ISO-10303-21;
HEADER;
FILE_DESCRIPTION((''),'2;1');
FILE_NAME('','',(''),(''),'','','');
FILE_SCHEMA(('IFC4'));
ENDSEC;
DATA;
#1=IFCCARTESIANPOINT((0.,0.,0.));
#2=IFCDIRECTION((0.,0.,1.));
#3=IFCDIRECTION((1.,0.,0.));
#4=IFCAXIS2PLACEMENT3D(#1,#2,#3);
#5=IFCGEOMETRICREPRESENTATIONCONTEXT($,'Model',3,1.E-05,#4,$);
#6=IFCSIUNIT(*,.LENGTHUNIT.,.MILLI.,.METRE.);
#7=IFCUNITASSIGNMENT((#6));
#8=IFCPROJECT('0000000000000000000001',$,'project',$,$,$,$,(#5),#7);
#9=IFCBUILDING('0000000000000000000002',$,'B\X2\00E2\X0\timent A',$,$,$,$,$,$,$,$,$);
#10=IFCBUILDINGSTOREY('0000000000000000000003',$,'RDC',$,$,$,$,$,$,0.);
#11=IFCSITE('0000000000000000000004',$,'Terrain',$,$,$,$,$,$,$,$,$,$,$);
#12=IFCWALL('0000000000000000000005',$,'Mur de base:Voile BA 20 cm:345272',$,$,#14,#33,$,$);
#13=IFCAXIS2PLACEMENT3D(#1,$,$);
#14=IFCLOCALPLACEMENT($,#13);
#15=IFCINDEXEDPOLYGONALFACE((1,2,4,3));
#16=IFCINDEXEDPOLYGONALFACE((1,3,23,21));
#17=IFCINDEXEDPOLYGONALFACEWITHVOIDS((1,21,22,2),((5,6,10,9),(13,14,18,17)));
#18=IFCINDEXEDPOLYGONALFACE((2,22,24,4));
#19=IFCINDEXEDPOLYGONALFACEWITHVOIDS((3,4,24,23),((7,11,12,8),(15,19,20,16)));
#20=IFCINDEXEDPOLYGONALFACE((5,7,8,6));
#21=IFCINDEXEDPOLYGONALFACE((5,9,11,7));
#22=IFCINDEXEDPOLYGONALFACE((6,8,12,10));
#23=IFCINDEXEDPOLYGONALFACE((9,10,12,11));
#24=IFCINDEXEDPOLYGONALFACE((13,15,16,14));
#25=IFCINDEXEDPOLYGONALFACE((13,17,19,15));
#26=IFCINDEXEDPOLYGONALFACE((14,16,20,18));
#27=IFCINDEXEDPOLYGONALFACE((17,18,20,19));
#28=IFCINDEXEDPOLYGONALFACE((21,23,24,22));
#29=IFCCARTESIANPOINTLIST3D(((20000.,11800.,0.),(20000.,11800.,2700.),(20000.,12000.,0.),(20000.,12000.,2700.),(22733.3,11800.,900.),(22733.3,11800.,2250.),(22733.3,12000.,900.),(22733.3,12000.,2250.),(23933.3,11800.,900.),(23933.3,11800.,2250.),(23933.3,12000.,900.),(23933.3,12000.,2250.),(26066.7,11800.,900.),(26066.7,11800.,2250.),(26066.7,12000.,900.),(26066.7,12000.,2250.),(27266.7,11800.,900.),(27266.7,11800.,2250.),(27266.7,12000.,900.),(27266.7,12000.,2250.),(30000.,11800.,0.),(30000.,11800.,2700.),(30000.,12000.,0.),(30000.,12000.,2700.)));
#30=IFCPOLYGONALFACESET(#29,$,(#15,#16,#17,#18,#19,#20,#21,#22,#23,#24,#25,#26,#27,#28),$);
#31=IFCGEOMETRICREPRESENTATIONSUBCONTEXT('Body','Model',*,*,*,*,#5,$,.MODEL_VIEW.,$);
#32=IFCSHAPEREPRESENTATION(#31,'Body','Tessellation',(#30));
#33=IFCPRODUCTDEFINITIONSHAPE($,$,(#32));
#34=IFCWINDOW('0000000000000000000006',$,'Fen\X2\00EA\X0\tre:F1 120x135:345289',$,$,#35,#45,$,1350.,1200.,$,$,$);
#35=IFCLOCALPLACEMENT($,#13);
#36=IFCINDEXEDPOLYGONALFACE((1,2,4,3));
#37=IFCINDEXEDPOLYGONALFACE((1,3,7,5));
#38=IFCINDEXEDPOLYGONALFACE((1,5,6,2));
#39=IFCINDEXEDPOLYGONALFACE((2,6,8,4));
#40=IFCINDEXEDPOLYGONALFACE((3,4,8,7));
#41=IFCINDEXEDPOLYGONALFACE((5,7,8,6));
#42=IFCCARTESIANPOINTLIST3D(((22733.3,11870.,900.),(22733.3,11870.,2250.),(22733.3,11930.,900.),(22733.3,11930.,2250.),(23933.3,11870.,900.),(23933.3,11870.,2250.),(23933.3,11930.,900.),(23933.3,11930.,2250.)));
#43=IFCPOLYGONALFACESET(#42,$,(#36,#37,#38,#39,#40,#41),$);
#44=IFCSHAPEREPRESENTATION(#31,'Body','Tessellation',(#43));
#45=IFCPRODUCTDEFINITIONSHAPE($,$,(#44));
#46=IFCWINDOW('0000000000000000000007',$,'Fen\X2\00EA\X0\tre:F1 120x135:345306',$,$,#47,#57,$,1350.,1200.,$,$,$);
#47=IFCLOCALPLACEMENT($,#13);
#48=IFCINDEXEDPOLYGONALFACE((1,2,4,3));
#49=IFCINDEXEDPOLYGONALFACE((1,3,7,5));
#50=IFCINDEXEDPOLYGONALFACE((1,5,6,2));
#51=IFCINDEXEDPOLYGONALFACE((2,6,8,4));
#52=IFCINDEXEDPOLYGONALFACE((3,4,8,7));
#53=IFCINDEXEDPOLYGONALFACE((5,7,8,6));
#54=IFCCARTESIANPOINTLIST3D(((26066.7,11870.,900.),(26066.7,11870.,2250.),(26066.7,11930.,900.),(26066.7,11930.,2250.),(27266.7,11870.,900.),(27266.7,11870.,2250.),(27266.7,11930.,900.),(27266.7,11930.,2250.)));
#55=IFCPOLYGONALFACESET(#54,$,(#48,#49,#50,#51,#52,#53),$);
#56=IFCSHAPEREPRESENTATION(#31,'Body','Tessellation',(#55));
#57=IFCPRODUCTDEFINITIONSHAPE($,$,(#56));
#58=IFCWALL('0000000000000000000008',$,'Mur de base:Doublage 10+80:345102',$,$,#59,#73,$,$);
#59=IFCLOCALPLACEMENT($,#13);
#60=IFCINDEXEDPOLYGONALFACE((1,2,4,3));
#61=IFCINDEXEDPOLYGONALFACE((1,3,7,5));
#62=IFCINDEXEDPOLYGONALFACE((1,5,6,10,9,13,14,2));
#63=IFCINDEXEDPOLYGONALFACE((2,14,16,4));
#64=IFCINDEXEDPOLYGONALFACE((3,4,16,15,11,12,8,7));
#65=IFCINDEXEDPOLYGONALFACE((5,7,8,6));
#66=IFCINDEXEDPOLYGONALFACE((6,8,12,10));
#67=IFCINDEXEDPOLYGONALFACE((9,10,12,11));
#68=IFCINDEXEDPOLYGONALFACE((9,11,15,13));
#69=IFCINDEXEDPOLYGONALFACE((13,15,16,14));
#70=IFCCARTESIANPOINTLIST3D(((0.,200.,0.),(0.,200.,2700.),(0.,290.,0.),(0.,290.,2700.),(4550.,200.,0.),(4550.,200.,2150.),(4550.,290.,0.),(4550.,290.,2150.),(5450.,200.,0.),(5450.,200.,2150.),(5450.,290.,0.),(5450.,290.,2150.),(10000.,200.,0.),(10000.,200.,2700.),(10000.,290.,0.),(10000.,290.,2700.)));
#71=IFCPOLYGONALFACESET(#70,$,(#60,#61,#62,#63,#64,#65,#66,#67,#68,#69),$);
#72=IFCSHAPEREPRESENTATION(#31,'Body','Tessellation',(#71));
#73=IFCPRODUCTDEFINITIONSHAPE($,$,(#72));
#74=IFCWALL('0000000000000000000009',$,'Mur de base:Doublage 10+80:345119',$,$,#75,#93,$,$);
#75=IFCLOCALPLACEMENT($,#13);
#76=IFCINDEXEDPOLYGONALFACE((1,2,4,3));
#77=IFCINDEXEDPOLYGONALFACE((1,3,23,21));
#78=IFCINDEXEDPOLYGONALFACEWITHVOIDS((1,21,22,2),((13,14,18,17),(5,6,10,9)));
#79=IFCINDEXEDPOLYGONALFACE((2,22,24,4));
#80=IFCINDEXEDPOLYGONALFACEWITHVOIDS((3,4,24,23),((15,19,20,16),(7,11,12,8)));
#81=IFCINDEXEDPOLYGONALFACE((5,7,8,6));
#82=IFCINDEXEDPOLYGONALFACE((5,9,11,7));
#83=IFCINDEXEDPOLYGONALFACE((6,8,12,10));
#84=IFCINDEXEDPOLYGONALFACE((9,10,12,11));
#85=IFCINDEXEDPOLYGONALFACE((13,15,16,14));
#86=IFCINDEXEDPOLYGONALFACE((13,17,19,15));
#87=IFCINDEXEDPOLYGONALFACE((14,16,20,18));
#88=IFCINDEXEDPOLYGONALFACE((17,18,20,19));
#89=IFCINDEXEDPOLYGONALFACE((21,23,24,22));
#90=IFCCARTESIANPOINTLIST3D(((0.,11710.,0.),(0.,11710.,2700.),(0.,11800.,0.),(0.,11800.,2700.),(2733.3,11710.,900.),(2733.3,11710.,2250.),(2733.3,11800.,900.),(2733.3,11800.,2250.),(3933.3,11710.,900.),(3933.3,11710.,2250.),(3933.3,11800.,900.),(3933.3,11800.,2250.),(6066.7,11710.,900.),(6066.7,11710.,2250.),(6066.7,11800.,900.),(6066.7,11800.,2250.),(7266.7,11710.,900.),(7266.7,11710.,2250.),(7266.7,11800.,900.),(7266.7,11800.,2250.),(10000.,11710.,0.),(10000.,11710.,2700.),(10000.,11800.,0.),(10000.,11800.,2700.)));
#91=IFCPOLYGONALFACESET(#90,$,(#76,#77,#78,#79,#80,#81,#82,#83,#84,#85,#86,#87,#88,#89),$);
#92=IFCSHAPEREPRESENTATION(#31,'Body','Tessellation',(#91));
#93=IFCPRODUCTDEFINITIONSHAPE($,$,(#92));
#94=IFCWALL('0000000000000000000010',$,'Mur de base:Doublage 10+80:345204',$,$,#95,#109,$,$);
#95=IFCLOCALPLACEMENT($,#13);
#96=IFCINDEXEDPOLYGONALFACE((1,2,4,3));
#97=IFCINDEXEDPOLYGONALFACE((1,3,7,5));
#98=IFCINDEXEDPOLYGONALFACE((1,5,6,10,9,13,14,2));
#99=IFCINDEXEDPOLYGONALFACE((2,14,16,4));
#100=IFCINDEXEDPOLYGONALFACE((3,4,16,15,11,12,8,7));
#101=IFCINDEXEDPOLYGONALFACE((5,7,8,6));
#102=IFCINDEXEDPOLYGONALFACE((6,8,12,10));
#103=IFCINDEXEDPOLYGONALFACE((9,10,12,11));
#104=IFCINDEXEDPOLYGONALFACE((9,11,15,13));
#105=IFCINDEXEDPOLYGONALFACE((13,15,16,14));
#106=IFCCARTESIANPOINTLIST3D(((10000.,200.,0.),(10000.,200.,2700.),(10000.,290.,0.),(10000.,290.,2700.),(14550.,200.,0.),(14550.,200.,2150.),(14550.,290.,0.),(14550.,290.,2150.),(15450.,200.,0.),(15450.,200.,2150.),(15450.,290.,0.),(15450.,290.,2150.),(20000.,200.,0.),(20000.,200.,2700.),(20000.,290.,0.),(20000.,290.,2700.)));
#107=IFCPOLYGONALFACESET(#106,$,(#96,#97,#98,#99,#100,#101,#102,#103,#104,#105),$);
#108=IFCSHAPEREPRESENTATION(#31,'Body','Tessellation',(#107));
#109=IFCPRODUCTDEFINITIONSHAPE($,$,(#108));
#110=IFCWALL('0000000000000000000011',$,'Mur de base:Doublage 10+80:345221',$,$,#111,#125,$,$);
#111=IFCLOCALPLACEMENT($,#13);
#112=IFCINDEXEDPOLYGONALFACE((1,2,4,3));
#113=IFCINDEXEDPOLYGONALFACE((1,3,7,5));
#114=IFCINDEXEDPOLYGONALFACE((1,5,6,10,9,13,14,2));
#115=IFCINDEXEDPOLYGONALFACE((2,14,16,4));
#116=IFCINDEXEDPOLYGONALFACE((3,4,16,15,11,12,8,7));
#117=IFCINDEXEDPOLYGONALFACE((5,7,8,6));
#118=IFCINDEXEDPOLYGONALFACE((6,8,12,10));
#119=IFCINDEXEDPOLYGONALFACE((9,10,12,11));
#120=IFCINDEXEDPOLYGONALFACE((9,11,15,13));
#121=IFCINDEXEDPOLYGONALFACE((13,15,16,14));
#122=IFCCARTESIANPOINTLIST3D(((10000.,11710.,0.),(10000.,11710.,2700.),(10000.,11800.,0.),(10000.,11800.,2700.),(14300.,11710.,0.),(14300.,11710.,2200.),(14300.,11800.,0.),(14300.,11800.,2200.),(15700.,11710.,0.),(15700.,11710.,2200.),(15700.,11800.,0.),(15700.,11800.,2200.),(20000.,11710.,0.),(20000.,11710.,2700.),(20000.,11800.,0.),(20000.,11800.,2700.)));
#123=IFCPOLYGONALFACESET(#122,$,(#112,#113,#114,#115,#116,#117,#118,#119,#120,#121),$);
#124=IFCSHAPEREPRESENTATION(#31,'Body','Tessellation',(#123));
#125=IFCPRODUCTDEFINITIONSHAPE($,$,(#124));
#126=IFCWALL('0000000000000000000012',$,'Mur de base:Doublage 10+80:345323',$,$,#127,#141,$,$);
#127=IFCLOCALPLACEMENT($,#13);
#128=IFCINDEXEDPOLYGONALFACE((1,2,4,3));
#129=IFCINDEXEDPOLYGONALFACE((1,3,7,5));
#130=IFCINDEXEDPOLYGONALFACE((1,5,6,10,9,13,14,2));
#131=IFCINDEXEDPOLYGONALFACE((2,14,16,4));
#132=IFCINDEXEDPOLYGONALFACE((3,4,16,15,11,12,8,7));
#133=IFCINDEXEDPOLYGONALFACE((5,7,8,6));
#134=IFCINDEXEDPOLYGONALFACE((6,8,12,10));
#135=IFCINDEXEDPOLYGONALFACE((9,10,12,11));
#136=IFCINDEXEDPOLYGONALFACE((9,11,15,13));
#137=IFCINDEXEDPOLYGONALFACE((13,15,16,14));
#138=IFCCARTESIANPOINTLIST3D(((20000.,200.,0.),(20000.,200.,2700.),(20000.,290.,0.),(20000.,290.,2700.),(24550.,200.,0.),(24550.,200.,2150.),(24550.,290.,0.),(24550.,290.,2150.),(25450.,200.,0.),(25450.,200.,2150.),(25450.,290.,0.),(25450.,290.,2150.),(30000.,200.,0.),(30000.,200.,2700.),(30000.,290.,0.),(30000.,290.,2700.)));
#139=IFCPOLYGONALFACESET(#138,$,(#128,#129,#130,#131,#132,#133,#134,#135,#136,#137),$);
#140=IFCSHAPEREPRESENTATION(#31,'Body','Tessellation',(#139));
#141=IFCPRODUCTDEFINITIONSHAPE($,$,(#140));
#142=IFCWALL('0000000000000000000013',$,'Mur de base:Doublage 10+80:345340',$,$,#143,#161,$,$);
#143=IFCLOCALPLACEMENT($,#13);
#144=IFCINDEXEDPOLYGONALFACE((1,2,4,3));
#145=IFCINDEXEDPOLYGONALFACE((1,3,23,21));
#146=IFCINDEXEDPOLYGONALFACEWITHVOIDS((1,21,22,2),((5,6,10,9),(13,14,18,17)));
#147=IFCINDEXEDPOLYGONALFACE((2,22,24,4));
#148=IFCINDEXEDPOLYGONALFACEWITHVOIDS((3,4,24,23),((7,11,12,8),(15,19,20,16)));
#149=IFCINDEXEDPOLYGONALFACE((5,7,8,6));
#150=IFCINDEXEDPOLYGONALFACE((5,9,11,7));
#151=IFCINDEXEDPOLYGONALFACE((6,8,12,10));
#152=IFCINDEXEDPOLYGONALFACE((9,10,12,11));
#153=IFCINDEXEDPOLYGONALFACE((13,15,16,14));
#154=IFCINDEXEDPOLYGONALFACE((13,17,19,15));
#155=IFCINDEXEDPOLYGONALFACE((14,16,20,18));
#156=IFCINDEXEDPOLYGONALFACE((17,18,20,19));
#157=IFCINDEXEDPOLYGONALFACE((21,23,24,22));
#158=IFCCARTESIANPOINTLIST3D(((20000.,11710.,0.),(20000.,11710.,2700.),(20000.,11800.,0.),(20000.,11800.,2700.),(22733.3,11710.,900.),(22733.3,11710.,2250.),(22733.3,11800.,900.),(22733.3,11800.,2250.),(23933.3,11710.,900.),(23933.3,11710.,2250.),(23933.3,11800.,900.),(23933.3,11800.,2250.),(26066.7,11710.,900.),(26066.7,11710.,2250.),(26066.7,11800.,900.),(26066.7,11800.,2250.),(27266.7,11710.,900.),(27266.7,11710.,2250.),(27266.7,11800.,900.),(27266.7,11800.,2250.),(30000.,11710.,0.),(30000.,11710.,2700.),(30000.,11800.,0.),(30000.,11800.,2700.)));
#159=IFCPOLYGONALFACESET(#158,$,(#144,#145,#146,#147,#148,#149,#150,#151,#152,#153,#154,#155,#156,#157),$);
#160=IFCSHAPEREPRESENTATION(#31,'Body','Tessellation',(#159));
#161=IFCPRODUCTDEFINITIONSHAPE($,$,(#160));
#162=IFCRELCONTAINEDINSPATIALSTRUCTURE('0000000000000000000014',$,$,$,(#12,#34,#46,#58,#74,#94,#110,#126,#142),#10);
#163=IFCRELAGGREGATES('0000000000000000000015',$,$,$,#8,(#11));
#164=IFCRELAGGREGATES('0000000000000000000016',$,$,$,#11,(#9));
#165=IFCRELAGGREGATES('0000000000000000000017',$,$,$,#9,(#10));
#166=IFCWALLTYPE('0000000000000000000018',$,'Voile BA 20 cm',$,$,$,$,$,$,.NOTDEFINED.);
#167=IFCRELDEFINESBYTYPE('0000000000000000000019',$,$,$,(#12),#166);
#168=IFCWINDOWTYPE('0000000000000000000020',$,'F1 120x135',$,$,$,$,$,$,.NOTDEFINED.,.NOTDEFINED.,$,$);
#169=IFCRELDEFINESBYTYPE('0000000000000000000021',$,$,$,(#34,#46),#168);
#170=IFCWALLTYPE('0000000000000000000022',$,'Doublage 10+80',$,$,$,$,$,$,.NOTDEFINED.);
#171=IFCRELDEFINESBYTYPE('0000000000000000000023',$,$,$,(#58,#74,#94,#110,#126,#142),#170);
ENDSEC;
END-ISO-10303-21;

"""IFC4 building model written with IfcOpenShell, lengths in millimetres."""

from ifc_helpers import new_model, si_unit, frame, frame_2d, origin_with_axes, place, context, subcontext, project, spatial, rectangle, extrude, type_object, element, fill, save


model = new_model("IFC4")

# Units and contexts
model_context = context("Model", 3, precision=1e-05, world=origin_with_axes())
body_context = subcontext(model_context, "Body", "Model", "MODEL_VIEW")
ifc_project = project(units=[si_unit("LENGTHUNIT", "METRE", prefix="MILLI")], contexts=[model_context])

# Site, building, storey
site = spatial("IfcSite", under=ifc_project, Name="Terrain")
building = spatial("IfcBuilding", under=site, Name="Bâtiment A")
storey = spatial("IfcBuildingStorey", under=building, Name="RDC", Elevation=0.0)

# Shared definitions
wall_type_1 = type_object("IfcWallType", Name="Voile BA 20 cm", PredefinedType="NOTDEFINED")

# Shared definitions
window_type = type_object("IfcWindowType", Name="F1 120x135", PartitioningType="NOTDEFINED", PredefinedType="NOTDEFINED")

# Wall, openings, windows
wall_1_placement = place(None, origin_with_axes())
wall_1 = element("IfcWall", 1, at=wall_1_placement, inside=storey, type_object=wall_type_1, Name="Mur de base:Voile BA 20 cm:345272", context=body_context, shape_type="SweptSolid", body=[
    extrude(rectangle(XDim=10000.0, YDim=200.0, at=frame_2d((25000.0, 11900.0))), origin_with_axes(), (0.0, 0.0, 1.0), 2700.0),
])
opening_1_placement = place(None, origin_with_axes())
opening_1 = element("IfcOpeningElement", 2, at=opening_1_placement, cuts=wall_1, context=body_context, shape_type="SweptSolid", body=[
    extrude(rectangle(XDim=1200.0, YDim=320.0, at=frame_2d((23333.3, 11900.0))), frame((0.0, 0.0, 900.0), z_axis=(0.0, 0.0, 1.0), x_axis=(1.0, 0.0, 0.0)), (0.0, 0.0, 1.0), 1350.0),
])
opening_2_placement = place(None, origin_with_axes())
opening_2 = element("IfcOpeningElement", 3, at=opening_2_placement, cuts=wall_1, context=body_context, shape_type="SweptSolid", body=[
    extrude(rectangle(XDim=1200.0, YDim=320.0, at=frame_2d((26666.7, 11900.0))), frame((0.0, 0.0, 900.0), z_axis=(0.0, 0.0, 1.0), x_axis=(1.0, 0.0, 0.0)), (0.0, 0.0, 1.0), 1350.0),
])
window_1_placement = place(None, origin_with_axes())
window_1 = element("IfcWindow", 4, at=window_1_placement, inside=storey, type_object=window_type, Name="Fenêtre:F1 120x135:345289", OverallHeight=1350.0, OverallWidth=1200.0, context=body_context, shape_type="SweptSolid", body=[
    extrude(rectangle(XDim=1200.0, YDim=60.0, at=frame_2d((23333.3, 11900.0))), frame((0.0, 0.0, 900.0), z_axis=(0.0, 0.0, 1.0), x_axis=(1.0, 0.0, 0.0)), (0.0, 0.0, 1.0), 1350.0),
])
fill(opening_1, window_1)
window_2_placement = place(None, origin_with_axes())
window_2 = element("IfcWindow", 5, at=window_2_placement, inside=storey, type_object=window_type, Name="Fenêtre:F1 120x135:345306", OverallHeight=1350.0, OverallWidth=1200.0, context=body_context, shape_type="SweptSolid", body=[
    extrude(rectangle(XDim=1200.0, YDim=60.0, at=frame_2d((26666.7, 11900.0))), frame((0.0, 0.0, 900.0), z_axis=(0.0, 0.0, 1.0), x_axis=(1.0, 0.0, 0.0)), (0.0, 0.0, 1.0), 1350.0),
])
fill(opening_2, window_2)

# Wall, opening
wall_type_2 = type_object("IfcWallType", Name="Doublage 10+80", PredefinedType="NOTDEFINED")
wall_2_placement = place(None, origin_with_axes())
wall_2 = element("IfcWall", 6, at=wall_2_placement, inside=storey, type_object=wall_type_2, Name="Mur de base:Doublage 10+80:345102", context=body_context, shape_type="SweptSolid", body=[
    extrude(rectangle(XDim=10000.0, YDim=90.0, at=frame_2d((5000.0, 245.0))), origin_with_axes(), (0.0, 0.0, 1.0), 2700.0),
])
opening_3_placement = place(None, origin_with_axes())
element("IfcOpeningElement", 7, at=opening_3_placement, cuts=wall_2, context=body_context, shape_type="SweptSolid", body=[
    extrude(rectangle(XDim=900.0, YDim=210.0, at=frame_2d((5000.0, 245.0))), origin_with_axes(), (0.0, 0.0, 1.0), 2150.0),
])

# Wall, openings
wall_3_placement = place(None, origin_with_axes())
wall_3 = element("IfcWall", 8, at=wall_3_placement, inside=storey, type_object=wall_type_2, Name="Mur de base:Doublage 10+80:345119", context=body_context, shape_type="SweptSolid", body=[
    extrude(rectangle(XDim=10000.0, YDim=90.0, at=frame_2d((5000.0, 11755.0))), origin_with_axes(), (0.0, 0.0, 1.0), 2700.0),
])
opening_4_placement = place(None, origin_with_axes())
element("IfcOpeningElement", 9, at=opening_4_placement, cuts=wall_3, context=body_context, shape_type="SweptSolid", body=[
    extrude(rectangle(XDim=1200.0, YDim=210.0, at=frame_2d((3333.3, 11755.0))), frame((0.0, 0.0, 900.0), z_axis=(0.0, 0.0, 1.0), x_axis=(1.0, 0.0, 0.0)), (0.0, 0.0, 1.0), 1350.0),
])
opening_5_placement = place(None, origin_with_axes())
element("IfcOpeningElement", 10, at=opening_5_placement, cuts=wall_3, context=body_context, shape_type="SweptSolid", body=[
    extrude(rectangle(XDim=1200.0, YDim=210.0, at=frame_2d((6666.7, 11755.0))), frame((0.0, 0.0, 900.0), z_axis=(0.0, 0.0, 1.0), x_axis=(1.0, 0.0, 0.0)), (0.0, 0.0, 1.0), 1350.0),
])

# Walls, openings
wall_4_placement = place(None, origin_with_axes())
wall_4 = element("IfcWall", 11, at=wall_4_placement, inside=storey, type_object=wall_type_2, Name="Mur de base:Doublage 10+80:345204", context=body_context, shape_type="SweptSolid", body=[
    extrude(rectangle(XDim=10000.0, YDim=90.0, at=frame_2d((15000.0, 245.0))), origin_with_axes(), (0.0, 0.0, 1.0), 2700.0),
])
opening_6_placement = place(None, origin_with_axes())
element("IfcOpeningElement", 12, at=opening_6_placement, cuts=wall_4, context=body_context, shape_type="SweptSolid", body=[
    extrude(rectangle(XDim=900.0, YDim=210.0, at=frame_2d((15000.0, 245.0))), origin_with_axes(), (0.0, 0.0, 1.0), 2150.0),
])
wall_5_placement = place(None, origin_with_axes())
wall_5 = element("IfcWall", 13, at=wall_5_placement, inside=storey, type_object=wall_type_2, Name="Mur de base:Doublage 10+80:345221", context=body_context, shape_type="SweptSolid", body=[
    extrude(rectangle(XDim=10000.0, YDim=90.0, at=frame_2d((15000.0, 11755.0))), origin_with_axes(), (0.0, 0.0, 1.0), 2700.0),
])
opening_7_placement = place(None, origin_with_axes())
element("IfcOpeningElement", 14, at=opening_7_placement, cuts=wall_5, context=body_context, shape_type="SweptSolid", body=[
    extrude(rectangle(XDim=1400.0, YDim=210.0, at=frame_2d((15000.0, 11755.0))), origin_with_axes(), (0.0, 0.0, 1.0), 2200.0),
])
wall_6_placement = place(None, origin_with_axes())
wall_6 = element("IfcWall", 15, at=wall_6_placement, inside=storey, type_object=wall_type_2, Name="Mur de base:Doublage 10+80:345323", context=body_context, shape_type="SweptSolid", body=[
    extrude(rectangle(XDim=10000.0, YDim=90.0, at=frame_2d((25000.0, 245.0))), origin_with_axes(), (0.0, 0.0, 1.0), 2700.0),
])
opening_8_placement = place(None, origin_with_axes())
element("IfcOpeningElement", 16, at=opening_8_placement, cuts=wall_6, context=body_context, shape_type="SweptSolid", body=[
    extrude(rectangle(XDim=900.0, YDim=210.0, at=frame_2d((25000.0, 245.0))), origin_with_axes(), (0.0, 0.0, 1.0), 2150.0),
])

# Wall, openings
wall_7_placement = place(None, origin_with_axes())
wall_7 = element("IfcWall", 17, at=wall_7_placement, inside=storey, type_object=wall_type_2, Name="Mur de base:Doublage 10+80:345340", context=body_context, shape_type="SweptSolid", body=[
    extrude(rectangle(XDim=10000.0, YDim=90.0, at=frame_2d((25000.0, 11755.0))), origin_with_axes(), (0.0, 0.0, 1.0), 2700.0),
])
opening_9_placement = place(None, origin_with_axes())
element("IfcOpeningElement", 18, at=opening_9_placement, cuts=wall_7, context=body_context, shape_type="SweptSolid", body=[
    extrude(rectangle(XDim=1200.0, YDim=210.0, at=frame_2d((23333.3, 11755.0))), frame((0.0, 0.0, 900.0), z_axis=(0.0, 0.0, 1.0), x_axis=(1.0, 0.0, 0.0)), (0.0, 0.0, 1.0), 1350.0),
])
opening_10_placement = place(None, origin_with_axes())
element("IfcOpeningElement", 19, at=opening_10_placement, cuts=wall_7, context=body_context, shape_type="SweptSolid", body=[
    extrude(rectangle(XDim=1200.0, YDim=210.0, at=frame_2d((26666.7, 11755.0))), frame((0.0, 0.0, 900.0), z_axis=(0.0, 0.0, 1.0), x_axis=(1.0, 0.0, 0.0)), (0.0, 0.0, 1.0), 1350.0),
])

save(model, "model.ifc")
